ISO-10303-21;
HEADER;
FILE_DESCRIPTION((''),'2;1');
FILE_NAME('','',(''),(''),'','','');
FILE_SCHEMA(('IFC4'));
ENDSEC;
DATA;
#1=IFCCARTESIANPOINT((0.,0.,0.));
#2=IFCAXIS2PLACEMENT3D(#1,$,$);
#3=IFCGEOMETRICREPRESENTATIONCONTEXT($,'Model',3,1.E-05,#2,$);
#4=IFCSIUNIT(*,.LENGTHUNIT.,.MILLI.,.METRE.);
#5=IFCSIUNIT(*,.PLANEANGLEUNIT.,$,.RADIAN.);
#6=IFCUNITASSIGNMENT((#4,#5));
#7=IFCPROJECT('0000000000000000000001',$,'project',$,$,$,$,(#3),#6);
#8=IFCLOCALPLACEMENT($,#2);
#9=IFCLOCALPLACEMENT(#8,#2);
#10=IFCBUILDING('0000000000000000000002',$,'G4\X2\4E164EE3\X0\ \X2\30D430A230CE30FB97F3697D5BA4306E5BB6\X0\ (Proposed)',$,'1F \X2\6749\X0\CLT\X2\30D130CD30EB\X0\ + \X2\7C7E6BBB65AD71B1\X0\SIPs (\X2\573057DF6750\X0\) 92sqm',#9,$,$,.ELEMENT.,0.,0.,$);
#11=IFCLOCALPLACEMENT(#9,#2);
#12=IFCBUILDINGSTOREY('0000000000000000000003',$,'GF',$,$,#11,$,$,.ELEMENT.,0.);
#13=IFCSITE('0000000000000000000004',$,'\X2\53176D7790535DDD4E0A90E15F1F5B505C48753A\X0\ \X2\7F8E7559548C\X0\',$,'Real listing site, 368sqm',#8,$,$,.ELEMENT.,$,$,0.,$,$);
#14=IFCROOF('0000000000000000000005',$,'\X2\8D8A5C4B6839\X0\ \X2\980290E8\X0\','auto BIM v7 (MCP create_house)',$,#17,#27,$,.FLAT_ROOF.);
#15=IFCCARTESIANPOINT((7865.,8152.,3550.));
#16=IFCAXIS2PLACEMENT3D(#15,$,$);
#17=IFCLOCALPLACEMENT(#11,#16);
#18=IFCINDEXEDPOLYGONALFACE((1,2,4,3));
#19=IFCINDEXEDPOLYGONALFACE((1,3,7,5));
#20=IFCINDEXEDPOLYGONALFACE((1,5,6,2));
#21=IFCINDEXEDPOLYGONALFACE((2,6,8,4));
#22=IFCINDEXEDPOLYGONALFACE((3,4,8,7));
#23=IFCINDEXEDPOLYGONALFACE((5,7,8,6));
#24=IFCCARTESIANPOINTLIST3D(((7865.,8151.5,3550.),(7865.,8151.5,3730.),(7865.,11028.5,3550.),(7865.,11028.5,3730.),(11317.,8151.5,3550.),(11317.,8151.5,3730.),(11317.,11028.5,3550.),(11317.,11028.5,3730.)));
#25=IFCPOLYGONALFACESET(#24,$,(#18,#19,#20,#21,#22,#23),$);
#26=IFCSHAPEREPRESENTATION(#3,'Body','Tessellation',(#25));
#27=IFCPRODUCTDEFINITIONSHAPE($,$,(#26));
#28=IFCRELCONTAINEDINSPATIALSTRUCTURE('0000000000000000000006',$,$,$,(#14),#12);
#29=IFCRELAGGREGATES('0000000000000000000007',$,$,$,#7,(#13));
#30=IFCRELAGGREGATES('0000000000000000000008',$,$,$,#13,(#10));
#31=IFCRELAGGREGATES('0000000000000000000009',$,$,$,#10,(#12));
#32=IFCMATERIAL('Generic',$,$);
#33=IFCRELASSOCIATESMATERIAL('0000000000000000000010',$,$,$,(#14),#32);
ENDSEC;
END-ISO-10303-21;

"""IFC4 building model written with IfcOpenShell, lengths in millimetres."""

from ifc_helpers import new_model, si_unit, frame, frame_2d, origin, place, context, project, spatial, rectangle, extrude, material, element, save


model = new_model("IFC4")

# Units and contexts
model_context = context("Model", 3, precision=1e-05, world=origin())
ifc_project = project(units=[si_unit("LENGTHUNIT", "METRE", prefix="MILLI"), si_unit("PLANEANGLEUNIT", "RADIAN")], contexts=[model_context])

# Site, building, storey
site_placement = place(None, origin())
site = spatial("IfcSite", under=ifc_project, at=site_placement, Name="北海道川上郡弟子屈町 美留和", ObjectType="Real listing site, 368sqm", CompositionType="ELEMENT", RefElevation=0.0)
building_placement = place(site_placement, origin())
building = spatial("IfcBuilding", under=site, at=building_placement, Name="G4世代 ピアノ・音楽室の家 (Proposed)", ObjectType="1F 杉CLTパネル + 籾殻断熱SIPs (地域材) 92sqm", CompositionType="ELEMENT", ElevationOfRefHeight=0.0, ElevationOfTerrain=0.0)
storey_placement = place(building_placement, origin())
storey = spatial("IfcBuildingStorey", under=building, at=storey_placement, Name="GF", CompositionType="ELEMENT", Elevation=0.0)

# Shared definitions
ifc_material = material(Name="Generic")

# Roof
roof_1_placement = place(storey_placement, frame((7865.0, 8152.0, 3550.0)))
element("IfcRoof", 1, at=roof_1_placement, inside=storey, material=ifc_material, Name="越屋根 頂部", Description="auto BIM v7 (MCP create_house)", PredefinedType="FLAT_ROOF", context=model_context, shape_type="SweptSolid", body=[
    extrude(rectangle(XDim=3452.0, YDim=2877.0, at=frame_2d((1726.0, 1438.0))), frame((7865.0, 8152.0, 3550.0)), (0.0, 0.0, 1.0), 180.0),
])

save(model, "model.ifc")
